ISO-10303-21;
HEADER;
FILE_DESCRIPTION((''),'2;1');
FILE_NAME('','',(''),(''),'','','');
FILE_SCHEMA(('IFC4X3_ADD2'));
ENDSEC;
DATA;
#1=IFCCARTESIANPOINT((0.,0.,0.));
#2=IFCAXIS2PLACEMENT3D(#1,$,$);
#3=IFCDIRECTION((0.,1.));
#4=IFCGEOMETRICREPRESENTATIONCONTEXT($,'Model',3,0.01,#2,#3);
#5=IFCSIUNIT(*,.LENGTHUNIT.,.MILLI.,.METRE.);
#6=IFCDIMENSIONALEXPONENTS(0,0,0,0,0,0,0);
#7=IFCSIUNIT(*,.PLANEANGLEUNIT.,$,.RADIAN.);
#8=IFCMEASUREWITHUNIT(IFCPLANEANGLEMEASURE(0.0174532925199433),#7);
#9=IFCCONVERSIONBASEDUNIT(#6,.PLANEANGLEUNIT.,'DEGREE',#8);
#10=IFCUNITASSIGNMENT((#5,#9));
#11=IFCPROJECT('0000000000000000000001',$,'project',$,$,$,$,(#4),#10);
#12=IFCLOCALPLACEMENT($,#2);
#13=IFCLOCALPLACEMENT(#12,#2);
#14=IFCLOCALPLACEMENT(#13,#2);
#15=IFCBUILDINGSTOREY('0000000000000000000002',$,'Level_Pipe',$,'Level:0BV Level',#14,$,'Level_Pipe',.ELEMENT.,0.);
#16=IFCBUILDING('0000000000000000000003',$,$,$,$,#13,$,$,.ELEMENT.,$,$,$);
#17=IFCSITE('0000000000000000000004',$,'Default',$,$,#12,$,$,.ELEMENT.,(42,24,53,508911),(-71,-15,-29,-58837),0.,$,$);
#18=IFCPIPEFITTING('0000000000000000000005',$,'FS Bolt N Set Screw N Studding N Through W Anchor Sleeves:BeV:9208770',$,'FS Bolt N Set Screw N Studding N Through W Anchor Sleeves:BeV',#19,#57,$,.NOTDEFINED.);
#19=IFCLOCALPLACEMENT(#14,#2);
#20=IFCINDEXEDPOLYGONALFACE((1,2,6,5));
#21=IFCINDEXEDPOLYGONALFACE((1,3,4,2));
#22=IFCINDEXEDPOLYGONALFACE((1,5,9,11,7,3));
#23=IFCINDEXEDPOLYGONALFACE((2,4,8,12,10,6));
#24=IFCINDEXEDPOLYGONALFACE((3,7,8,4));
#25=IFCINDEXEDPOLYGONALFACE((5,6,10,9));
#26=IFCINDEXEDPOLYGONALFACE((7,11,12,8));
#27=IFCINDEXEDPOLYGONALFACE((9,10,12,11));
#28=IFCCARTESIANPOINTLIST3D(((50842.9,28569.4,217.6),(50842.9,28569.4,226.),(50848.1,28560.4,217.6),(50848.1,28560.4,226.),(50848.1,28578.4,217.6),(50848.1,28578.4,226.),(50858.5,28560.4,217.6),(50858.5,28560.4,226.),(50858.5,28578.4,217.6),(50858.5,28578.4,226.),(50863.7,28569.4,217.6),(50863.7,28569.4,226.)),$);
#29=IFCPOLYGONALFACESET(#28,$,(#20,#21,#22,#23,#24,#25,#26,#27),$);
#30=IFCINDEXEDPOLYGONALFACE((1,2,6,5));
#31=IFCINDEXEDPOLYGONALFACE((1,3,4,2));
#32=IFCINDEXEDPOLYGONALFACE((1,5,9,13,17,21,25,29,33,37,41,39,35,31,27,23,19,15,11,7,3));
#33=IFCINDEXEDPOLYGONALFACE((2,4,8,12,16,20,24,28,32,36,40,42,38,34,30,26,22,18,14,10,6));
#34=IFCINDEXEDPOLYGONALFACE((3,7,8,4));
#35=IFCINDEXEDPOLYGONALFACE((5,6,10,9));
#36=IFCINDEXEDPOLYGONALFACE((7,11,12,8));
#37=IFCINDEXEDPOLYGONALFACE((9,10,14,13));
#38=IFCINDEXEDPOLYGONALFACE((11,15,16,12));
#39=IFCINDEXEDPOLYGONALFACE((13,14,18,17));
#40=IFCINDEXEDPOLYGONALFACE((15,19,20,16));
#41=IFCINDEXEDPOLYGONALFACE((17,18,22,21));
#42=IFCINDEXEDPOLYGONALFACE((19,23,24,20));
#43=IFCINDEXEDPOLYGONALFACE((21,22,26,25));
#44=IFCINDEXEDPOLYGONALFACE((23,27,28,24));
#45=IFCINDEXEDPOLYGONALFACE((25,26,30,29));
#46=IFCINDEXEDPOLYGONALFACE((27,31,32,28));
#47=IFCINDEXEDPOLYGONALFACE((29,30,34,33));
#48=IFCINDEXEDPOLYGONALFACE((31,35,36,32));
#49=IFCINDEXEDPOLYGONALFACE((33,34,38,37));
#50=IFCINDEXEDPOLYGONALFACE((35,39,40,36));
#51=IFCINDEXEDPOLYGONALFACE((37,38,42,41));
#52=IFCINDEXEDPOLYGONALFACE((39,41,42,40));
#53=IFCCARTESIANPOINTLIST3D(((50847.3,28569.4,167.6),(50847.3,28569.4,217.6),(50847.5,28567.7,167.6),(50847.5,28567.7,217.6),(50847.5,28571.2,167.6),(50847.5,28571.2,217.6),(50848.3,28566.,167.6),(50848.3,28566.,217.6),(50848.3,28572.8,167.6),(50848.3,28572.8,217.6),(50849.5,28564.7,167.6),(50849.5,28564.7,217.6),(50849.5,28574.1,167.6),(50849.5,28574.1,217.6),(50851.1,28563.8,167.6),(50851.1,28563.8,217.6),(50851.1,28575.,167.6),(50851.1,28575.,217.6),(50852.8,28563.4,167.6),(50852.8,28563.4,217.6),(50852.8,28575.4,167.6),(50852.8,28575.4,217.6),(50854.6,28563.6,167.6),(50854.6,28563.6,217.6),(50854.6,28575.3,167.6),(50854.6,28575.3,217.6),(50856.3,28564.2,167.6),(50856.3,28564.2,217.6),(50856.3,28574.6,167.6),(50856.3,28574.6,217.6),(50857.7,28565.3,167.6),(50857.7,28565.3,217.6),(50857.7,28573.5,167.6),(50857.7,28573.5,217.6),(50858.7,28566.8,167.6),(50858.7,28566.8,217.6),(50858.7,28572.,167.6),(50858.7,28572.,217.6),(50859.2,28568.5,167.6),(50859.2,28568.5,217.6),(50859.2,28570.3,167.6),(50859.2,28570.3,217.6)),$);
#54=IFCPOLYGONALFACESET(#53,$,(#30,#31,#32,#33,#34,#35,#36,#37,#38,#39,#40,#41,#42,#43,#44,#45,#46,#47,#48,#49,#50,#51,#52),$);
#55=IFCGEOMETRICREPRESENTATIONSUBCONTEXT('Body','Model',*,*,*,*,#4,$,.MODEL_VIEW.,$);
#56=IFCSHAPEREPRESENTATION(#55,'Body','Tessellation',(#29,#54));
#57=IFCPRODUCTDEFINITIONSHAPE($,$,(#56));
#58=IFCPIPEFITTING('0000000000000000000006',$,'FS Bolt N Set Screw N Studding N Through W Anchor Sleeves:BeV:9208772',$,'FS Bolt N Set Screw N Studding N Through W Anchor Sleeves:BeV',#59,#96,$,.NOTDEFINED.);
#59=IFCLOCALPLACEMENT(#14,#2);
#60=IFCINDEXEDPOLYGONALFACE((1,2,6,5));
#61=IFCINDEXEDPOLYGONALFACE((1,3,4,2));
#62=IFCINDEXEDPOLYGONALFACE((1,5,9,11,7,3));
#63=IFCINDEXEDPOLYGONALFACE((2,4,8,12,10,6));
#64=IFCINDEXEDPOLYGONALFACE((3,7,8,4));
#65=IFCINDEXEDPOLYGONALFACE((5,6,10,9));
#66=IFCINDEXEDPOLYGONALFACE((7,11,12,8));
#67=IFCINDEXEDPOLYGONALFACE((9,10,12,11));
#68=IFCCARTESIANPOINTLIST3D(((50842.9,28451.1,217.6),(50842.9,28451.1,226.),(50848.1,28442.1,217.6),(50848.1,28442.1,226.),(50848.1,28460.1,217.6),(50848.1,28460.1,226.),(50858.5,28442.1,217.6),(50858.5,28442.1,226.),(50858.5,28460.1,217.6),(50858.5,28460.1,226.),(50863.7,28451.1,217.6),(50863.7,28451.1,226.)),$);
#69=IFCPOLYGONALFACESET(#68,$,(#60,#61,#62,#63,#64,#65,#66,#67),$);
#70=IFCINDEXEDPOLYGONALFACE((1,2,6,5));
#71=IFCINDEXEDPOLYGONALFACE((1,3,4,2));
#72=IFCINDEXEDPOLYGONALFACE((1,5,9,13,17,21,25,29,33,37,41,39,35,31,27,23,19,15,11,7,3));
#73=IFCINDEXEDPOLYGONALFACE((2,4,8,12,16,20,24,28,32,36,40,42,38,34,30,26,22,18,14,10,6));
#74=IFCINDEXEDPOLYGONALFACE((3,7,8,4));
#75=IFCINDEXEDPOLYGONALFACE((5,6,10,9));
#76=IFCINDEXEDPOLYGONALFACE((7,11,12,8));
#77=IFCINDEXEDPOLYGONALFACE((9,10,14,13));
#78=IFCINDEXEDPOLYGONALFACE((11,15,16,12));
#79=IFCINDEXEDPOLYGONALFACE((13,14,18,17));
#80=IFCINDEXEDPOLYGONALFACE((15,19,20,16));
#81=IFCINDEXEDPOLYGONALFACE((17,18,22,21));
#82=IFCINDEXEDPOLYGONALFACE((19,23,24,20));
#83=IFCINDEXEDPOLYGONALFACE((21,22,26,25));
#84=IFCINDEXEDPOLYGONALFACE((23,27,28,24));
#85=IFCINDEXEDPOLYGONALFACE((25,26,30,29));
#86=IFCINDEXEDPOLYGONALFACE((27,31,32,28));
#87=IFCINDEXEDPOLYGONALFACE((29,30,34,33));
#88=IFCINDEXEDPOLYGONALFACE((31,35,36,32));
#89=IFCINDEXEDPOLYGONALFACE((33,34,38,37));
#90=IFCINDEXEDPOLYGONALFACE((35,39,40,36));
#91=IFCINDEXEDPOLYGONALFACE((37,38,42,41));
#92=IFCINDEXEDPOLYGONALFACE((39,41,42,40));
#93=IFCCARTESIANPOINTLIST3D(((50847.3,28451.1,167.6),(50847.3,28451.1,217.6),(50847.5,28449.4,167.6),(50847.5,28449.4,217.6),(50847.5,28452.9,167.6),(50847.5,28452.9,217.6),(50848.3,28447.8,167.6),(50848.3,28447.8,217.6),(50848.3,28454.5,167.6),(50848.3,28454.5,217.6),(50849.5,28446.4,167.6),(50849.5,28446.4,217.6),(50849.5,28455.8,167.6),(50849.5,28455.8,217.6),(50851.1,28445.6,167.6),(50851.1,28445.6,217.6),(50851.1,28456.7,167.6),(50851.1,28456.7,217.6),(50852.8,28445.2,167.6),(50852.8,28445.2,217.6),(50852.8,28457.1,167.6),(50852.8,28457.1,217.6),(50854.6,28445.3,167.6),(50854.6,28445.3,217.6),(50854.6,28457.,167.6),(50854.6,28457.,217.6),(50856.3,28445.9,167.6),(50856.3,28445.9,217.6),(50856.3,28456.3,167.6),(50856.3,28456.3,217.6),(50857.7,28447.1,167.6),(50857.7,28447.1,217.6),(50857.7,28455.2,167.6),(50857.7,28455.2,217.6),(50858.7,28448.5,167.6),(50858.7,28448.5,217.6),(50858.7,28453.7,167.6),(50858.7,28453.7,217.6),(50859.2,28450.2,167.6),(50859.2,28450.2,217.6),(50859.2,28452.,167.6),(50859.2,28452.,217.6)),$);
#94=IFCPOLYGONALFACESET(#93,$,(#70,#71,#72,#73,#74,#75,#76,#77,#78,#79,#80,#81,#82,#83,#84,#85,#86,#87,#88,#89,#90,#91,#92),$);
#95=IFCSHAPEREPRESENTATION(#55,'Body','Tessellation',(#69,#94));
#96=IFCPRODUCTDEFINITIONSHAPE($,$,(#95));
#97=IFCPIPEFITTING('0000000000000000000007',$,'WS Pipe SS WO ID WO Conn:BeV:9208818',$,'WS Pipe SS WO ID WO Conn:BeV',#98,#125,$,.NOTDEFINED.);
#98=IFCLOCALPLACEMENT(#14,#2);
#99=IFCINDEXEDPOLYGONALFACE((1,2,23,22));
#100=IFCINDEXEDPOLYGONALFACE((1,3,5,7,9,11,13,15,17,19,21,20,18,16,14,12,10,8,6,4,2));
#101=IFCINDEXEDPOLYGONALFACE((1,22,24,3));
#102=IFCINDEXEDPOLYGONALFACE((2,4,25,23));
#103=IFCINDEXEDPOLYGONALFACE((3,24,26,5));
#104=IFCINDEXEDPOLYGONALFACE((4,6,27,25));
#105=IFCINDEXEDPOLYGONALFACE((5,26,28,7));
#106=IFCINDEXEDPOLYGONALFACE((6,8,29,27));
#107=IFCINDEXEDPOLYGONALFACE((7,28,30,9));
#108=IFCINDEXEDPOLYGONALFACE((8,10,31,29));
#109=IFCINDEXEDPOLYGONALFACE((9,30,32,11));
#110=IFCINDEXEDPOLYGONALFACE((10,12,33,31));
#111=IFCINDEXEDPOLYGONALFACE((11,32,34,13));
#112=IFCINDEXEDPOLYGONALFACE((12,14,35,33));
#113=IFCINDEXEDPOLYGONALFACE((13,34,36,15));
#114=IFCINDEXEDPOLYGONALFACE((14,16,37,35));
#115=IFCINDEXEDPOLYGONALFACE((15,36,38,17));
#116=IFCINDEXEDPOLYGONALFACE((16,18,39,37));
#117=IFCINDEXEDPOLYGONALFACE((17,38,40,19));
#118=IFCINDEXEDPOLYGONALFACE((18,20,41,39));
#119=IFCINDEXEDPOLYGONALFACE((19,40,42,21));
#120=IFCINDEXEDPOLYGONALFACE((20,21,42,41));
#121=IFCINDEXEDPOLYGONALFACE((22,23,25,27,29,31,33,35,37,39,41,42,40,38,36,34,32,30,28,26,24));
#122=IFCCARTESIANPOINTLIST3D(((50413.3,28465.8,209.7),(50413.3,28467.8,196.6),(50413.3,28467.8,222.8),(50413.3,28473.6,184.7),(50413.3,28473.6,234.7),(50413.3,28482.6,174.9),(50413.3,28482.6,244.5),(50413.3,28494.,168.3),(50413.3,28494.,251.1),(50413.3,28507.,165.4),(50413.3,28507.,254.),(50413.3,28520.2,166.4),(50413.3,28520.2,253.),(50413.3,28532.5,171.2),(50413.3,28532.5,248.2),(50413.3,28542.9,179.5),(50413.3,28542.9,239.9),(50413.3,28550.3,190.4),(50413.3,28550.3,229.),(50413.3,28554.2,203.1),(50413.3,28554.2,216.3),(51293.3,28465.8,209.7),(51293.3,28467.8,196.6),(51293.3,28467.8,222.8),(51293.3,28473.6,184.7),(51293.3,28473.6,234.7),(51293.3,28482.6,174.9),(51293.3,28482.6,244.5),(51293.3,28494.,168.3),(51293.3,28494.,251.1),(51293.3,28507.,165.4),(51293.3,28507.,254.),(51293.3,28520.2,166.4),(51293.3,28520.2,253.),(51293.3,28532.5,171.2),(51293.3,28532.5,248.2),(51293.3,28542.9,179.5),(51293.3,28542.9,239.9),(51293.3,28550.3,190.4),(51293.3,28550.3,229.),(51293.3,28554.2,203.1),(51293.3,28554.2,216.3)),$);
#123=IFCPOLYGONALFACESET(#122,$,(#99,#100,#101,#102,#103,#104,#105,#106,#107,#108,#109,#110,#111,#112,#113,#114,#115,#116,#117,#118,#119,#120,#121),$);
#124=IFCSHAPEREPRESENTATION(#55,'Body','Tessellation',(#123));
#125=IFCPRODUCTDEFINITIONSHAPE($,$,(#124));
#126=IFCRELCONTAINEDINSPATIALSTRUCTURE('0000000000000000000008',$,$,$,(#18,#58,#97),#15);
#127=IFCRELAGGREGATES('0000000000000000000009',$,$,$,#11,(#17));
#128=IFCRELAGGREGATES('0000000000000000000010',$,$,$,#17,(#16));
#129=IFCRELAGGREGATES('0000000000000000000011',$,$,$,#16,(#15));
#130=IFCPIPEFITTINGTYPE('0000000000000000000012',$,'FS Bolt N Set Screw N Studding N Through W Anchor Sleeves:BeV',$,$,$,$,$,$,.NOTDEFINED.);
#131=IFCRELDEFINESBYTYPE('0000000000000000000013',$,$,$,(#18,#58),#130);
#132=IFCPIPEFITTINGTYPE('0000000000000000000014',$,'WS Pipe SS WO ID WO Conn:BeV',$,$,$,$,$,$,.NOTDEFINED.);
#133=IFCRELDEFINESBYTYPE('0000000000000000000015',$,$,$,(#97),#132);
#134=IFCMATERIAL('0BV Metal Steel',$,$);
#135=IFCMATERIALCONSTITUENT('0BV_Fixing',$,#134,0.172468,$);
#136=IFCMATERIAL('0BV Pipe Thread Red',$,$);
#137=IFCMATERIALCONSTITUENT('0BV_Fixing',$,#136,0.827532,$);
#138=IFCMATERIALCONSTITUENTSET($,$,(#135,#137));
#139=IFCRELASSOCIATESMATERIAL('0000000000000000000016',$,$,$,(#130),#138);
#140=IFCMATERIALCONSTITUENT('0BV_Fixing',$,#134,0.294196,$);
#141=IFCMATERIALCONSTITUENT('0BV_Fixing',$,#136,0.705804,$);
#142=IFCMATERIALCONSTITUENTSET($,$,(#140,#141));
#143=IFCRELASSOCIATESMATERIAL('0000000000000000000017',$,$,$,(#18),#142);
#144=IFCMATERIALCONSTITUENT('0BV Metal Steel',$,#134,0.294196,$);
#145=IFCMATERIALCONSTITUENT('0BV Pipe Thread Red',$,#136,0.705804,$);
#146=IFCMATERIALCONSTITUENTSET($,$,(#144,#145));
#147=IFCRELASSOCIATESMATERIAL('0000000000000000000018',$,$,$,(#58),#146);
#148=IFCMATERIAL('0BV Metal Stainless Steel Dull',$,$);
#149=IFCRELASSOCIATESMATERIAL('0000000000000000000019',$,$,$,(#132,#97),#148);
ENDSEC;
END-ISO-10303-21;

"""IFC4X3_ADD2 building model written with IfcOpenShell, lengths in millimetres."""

from ifc_helpers import new_model, entity, si_unit, converted_unit, direction, frame, frame_2d, origin, place, context, subcontext, project, spatial, polyline, circle, outline, extrude, source, transform, mapped, material, constituent, constituent_set, type_object, type_shapes, element, save


model = new_model("IFC4X3_ADD2")

# Units and contexts
model_context = context("Model", 3, precision=0.01, world=origin(), true_north=direction((0.0, 1.0)))
body_context = subcontext(model_context, "Body", "Model", "MODEL_VIEW")
ifc_project = project(units=[si_unit("LENGTHUNIT", "METRE", prefix="MILLI"), converted_unit("PLANEANGLEUNIT", "DEGREE", entity("IfcPlaneAngleMeasure", 0.0174532925199433), si_unit("PLANEANGLEUNIT", "RADIAN"), dimensions=[0, 0, 0, 0, 0, 0, 0])], contexts=[model_context])

# Site, building, storey
site_placement = place(None, origin())
site = spatial("IfcSite", under=ifc_project, at=site_placement, Name="Default", CompositionType="ELEMENT", RefLatitude=(42, 24, 53, 508911), RefLongitude=(-71, -15, -29, -58837), RefElevation=0.0)
building_placement = place(site_placement, origin())
building = spatial("IfcBuilding", under=site, at=building_placement, CompositionType="ELEMENT")
storey_placement = place(building_placement, origin())
storey = spatial("IfcBuildingStorey", under=building, at=storey_placement, Name="Level_Pipe", ObjectType="Level:0BV Level", LongName="Level_Pipe", CompositionType="ELEMENT", Elevation=0.0)

# Pipe fittings
ifc_material_1 = material(Name="0BV Metal Stainless Steel Dull")
ifc_material_2 = material(Name="0BV Metal Steel")
ifc_material_3 = material(Name="0BV Pipe Thread Red")
ifc_constituent_1 = constituent(ifc_material_2, Name="0BV_Fixing", fraction=0.294196)
ifc_constituent_2 = constituent(ifc_material_3, Name="0BV_Fixing", fraction=0.705804)
ifc_constituent_set_1 = constituent_set(constituents=[ifc_constituent_1, ifc_constituent_2])
ifc_constituent_3 = constituent(ifc_material_2, Name="0BV_Fixing", fraction=0.172468)
ifc_constituent_4 = constituent(ifc_material_3, Name="0BV_Fixing", fraction=0.827532)
ifc_constituent_set_2 = constituent_set(constituents=[ifc_constituent_3, ifc_constituent_4])
pipe_fitting_type_1 = type_object("IfcPipeFittingType", Name="FS Bolt N Set Screw N Studding N Through W Anchor Sleeves:BeV", PredefinedType="NOTDEFINED", material=ifc_constituent_set_2)
shared_shape_1 = source(origin(), body_context, "Body", "SweptSolid", [
    extrude(outline(polyline([(-5.2, -9.0), (5.2, -9.0), (10.4, 0.0), (5.2, 9.0), (-5.2, 9.0), (-10.4, 0.0), (-5.2, -9.0)])), frame((-8.4, 0.0, 0.0), z_axis=(1.0, 0.0, 0.0), x_axis=(0.0, -0.5, -0.866025)), (0.0, 0.0, 1.0), 8.4),
    extrude(circle(Radius=6.0, at=frame_2d((0.0, 0.0), x_axis=(1.0, 0.0))), frame((0.0, 0.0, 0.0), z_axis=(1.0, 0.0, 0.0), x_axis=(0.0, 1.0, 0.0)), (0.0, 0.0, 1.0), 50.0),
])
type_shapes(pipe_fitting_type_1, [shared_shape_1])
pipe_fitting_1_placement = place(storey_placement, frame((50853.3, 28569.4, 217.6), z_axis=(0.0, 1.0, 0.0), x_axis=(0.0, 0.0, -1.0)))
element("IfcPipeFitting", 1, at=pipe_fitting_1_placement, inside=storey, type_object=pipe_fitting_type_1, material=ifc_constituent_set_1, Name="FS Bolt N Set Screw N Studding N Through W Anchor Sleeves:BeV:9208770", ObjectType="FS Bolt N Set Screw N Studding N Through W Anchor Sleeves:BeV", PredefinedType="NOTDEFINED", context=body_context, shape_type="MappedRepresentation", body=[
    mapped(shared_shape_1, transform((0.0, 0.0, 0.0), scale=1.0)),
])
ifc_constituent_5 = constituent(ifc_material_2, Name="0BV Metal Steel", fraction=0.294196)
ifc_constituent_6 = constituent(ifc_material_3, Name="0BV Pipe Thread Red", fraction=0.705804)
ifc_constituent_set_3 = constituent_set(constituents=[ifc_constituent_5, ifc_constituent_6])
pipe_fitting_2_placement = place(storey_placement, frame((50853.3, 28451.1, 217.6), z_axis=(0.0, 1.0, 0.0), x_axis=(0.0, 0.0, -1.0)))
element("IfcPipeFitting", 2, at=pipe_fitting_2_placement, inside=storey, type_object=pipe_fitting_type_1, material=ifc_constituent_set_3, Name="FS Bolt N Set Screw N Studding N Through W Anchor Sleeves:BeV:9208772", ObjectType="FS Bolt N Set Screw N Studding N Through W Anchor Sleeves:BeV", PredefinedType="NOTDEFINED", context=body_context, shape_type="MappedRepresentation", body=[
    mapped(shared_shape_1, transform((0.0, 0.0, 0.0), scale=1.0)),
])
pipe_fitting_type_2 = type_object("IfcPipeFittingType", Name="WS Pipe SS WO ID WO Conn:BeV", PredefinedType="NOTDEFINED", material=ifc_material_1)
shared_shape_2 = source(origin(), body_context, "Body", "SweptSolid", [
    extrude(circle(Radius=44.5, at=frame_2d((0.0, 0.0), x_axis=(1.0, 0.0))), frame((-440.0, 0.0, 0.0), z_axis=(1.0, 0.0, 0.0), x_axis=(0.0, 1.0, 0.0)), (0.0, 0.0, 1.0), 880.0),
])
type_shapes(pipe_fitting_type_2, [shared_shape_2])
pipe_fitting_3_placement = place(storey_placement, frame((50853.3, 28510.3, 209.7), z_axis=(0.0, 0.0, 1.0), x_axis=(-1.0, 0.0, 0.0)))
element("IfcPipeFitting", 3, at=pipe_fitting_3_placement, inside=storey, type_object=pipe_fitting_type_2, material=ifc_material_1, Name="WS Pipe SS WO ID WO Conn:BeV:9208818", ObjectType="WS Pipe SS WO ID WO Conn:BeV", PredefinedType="NOTDEFINED", context=body_context, shape_type="MappedRepresentation", body=[
    mapped(shared_shape_2, transform((0.0, 0.0, 0.0), scale=1.0)),
])

save(model, "model.ifc")
